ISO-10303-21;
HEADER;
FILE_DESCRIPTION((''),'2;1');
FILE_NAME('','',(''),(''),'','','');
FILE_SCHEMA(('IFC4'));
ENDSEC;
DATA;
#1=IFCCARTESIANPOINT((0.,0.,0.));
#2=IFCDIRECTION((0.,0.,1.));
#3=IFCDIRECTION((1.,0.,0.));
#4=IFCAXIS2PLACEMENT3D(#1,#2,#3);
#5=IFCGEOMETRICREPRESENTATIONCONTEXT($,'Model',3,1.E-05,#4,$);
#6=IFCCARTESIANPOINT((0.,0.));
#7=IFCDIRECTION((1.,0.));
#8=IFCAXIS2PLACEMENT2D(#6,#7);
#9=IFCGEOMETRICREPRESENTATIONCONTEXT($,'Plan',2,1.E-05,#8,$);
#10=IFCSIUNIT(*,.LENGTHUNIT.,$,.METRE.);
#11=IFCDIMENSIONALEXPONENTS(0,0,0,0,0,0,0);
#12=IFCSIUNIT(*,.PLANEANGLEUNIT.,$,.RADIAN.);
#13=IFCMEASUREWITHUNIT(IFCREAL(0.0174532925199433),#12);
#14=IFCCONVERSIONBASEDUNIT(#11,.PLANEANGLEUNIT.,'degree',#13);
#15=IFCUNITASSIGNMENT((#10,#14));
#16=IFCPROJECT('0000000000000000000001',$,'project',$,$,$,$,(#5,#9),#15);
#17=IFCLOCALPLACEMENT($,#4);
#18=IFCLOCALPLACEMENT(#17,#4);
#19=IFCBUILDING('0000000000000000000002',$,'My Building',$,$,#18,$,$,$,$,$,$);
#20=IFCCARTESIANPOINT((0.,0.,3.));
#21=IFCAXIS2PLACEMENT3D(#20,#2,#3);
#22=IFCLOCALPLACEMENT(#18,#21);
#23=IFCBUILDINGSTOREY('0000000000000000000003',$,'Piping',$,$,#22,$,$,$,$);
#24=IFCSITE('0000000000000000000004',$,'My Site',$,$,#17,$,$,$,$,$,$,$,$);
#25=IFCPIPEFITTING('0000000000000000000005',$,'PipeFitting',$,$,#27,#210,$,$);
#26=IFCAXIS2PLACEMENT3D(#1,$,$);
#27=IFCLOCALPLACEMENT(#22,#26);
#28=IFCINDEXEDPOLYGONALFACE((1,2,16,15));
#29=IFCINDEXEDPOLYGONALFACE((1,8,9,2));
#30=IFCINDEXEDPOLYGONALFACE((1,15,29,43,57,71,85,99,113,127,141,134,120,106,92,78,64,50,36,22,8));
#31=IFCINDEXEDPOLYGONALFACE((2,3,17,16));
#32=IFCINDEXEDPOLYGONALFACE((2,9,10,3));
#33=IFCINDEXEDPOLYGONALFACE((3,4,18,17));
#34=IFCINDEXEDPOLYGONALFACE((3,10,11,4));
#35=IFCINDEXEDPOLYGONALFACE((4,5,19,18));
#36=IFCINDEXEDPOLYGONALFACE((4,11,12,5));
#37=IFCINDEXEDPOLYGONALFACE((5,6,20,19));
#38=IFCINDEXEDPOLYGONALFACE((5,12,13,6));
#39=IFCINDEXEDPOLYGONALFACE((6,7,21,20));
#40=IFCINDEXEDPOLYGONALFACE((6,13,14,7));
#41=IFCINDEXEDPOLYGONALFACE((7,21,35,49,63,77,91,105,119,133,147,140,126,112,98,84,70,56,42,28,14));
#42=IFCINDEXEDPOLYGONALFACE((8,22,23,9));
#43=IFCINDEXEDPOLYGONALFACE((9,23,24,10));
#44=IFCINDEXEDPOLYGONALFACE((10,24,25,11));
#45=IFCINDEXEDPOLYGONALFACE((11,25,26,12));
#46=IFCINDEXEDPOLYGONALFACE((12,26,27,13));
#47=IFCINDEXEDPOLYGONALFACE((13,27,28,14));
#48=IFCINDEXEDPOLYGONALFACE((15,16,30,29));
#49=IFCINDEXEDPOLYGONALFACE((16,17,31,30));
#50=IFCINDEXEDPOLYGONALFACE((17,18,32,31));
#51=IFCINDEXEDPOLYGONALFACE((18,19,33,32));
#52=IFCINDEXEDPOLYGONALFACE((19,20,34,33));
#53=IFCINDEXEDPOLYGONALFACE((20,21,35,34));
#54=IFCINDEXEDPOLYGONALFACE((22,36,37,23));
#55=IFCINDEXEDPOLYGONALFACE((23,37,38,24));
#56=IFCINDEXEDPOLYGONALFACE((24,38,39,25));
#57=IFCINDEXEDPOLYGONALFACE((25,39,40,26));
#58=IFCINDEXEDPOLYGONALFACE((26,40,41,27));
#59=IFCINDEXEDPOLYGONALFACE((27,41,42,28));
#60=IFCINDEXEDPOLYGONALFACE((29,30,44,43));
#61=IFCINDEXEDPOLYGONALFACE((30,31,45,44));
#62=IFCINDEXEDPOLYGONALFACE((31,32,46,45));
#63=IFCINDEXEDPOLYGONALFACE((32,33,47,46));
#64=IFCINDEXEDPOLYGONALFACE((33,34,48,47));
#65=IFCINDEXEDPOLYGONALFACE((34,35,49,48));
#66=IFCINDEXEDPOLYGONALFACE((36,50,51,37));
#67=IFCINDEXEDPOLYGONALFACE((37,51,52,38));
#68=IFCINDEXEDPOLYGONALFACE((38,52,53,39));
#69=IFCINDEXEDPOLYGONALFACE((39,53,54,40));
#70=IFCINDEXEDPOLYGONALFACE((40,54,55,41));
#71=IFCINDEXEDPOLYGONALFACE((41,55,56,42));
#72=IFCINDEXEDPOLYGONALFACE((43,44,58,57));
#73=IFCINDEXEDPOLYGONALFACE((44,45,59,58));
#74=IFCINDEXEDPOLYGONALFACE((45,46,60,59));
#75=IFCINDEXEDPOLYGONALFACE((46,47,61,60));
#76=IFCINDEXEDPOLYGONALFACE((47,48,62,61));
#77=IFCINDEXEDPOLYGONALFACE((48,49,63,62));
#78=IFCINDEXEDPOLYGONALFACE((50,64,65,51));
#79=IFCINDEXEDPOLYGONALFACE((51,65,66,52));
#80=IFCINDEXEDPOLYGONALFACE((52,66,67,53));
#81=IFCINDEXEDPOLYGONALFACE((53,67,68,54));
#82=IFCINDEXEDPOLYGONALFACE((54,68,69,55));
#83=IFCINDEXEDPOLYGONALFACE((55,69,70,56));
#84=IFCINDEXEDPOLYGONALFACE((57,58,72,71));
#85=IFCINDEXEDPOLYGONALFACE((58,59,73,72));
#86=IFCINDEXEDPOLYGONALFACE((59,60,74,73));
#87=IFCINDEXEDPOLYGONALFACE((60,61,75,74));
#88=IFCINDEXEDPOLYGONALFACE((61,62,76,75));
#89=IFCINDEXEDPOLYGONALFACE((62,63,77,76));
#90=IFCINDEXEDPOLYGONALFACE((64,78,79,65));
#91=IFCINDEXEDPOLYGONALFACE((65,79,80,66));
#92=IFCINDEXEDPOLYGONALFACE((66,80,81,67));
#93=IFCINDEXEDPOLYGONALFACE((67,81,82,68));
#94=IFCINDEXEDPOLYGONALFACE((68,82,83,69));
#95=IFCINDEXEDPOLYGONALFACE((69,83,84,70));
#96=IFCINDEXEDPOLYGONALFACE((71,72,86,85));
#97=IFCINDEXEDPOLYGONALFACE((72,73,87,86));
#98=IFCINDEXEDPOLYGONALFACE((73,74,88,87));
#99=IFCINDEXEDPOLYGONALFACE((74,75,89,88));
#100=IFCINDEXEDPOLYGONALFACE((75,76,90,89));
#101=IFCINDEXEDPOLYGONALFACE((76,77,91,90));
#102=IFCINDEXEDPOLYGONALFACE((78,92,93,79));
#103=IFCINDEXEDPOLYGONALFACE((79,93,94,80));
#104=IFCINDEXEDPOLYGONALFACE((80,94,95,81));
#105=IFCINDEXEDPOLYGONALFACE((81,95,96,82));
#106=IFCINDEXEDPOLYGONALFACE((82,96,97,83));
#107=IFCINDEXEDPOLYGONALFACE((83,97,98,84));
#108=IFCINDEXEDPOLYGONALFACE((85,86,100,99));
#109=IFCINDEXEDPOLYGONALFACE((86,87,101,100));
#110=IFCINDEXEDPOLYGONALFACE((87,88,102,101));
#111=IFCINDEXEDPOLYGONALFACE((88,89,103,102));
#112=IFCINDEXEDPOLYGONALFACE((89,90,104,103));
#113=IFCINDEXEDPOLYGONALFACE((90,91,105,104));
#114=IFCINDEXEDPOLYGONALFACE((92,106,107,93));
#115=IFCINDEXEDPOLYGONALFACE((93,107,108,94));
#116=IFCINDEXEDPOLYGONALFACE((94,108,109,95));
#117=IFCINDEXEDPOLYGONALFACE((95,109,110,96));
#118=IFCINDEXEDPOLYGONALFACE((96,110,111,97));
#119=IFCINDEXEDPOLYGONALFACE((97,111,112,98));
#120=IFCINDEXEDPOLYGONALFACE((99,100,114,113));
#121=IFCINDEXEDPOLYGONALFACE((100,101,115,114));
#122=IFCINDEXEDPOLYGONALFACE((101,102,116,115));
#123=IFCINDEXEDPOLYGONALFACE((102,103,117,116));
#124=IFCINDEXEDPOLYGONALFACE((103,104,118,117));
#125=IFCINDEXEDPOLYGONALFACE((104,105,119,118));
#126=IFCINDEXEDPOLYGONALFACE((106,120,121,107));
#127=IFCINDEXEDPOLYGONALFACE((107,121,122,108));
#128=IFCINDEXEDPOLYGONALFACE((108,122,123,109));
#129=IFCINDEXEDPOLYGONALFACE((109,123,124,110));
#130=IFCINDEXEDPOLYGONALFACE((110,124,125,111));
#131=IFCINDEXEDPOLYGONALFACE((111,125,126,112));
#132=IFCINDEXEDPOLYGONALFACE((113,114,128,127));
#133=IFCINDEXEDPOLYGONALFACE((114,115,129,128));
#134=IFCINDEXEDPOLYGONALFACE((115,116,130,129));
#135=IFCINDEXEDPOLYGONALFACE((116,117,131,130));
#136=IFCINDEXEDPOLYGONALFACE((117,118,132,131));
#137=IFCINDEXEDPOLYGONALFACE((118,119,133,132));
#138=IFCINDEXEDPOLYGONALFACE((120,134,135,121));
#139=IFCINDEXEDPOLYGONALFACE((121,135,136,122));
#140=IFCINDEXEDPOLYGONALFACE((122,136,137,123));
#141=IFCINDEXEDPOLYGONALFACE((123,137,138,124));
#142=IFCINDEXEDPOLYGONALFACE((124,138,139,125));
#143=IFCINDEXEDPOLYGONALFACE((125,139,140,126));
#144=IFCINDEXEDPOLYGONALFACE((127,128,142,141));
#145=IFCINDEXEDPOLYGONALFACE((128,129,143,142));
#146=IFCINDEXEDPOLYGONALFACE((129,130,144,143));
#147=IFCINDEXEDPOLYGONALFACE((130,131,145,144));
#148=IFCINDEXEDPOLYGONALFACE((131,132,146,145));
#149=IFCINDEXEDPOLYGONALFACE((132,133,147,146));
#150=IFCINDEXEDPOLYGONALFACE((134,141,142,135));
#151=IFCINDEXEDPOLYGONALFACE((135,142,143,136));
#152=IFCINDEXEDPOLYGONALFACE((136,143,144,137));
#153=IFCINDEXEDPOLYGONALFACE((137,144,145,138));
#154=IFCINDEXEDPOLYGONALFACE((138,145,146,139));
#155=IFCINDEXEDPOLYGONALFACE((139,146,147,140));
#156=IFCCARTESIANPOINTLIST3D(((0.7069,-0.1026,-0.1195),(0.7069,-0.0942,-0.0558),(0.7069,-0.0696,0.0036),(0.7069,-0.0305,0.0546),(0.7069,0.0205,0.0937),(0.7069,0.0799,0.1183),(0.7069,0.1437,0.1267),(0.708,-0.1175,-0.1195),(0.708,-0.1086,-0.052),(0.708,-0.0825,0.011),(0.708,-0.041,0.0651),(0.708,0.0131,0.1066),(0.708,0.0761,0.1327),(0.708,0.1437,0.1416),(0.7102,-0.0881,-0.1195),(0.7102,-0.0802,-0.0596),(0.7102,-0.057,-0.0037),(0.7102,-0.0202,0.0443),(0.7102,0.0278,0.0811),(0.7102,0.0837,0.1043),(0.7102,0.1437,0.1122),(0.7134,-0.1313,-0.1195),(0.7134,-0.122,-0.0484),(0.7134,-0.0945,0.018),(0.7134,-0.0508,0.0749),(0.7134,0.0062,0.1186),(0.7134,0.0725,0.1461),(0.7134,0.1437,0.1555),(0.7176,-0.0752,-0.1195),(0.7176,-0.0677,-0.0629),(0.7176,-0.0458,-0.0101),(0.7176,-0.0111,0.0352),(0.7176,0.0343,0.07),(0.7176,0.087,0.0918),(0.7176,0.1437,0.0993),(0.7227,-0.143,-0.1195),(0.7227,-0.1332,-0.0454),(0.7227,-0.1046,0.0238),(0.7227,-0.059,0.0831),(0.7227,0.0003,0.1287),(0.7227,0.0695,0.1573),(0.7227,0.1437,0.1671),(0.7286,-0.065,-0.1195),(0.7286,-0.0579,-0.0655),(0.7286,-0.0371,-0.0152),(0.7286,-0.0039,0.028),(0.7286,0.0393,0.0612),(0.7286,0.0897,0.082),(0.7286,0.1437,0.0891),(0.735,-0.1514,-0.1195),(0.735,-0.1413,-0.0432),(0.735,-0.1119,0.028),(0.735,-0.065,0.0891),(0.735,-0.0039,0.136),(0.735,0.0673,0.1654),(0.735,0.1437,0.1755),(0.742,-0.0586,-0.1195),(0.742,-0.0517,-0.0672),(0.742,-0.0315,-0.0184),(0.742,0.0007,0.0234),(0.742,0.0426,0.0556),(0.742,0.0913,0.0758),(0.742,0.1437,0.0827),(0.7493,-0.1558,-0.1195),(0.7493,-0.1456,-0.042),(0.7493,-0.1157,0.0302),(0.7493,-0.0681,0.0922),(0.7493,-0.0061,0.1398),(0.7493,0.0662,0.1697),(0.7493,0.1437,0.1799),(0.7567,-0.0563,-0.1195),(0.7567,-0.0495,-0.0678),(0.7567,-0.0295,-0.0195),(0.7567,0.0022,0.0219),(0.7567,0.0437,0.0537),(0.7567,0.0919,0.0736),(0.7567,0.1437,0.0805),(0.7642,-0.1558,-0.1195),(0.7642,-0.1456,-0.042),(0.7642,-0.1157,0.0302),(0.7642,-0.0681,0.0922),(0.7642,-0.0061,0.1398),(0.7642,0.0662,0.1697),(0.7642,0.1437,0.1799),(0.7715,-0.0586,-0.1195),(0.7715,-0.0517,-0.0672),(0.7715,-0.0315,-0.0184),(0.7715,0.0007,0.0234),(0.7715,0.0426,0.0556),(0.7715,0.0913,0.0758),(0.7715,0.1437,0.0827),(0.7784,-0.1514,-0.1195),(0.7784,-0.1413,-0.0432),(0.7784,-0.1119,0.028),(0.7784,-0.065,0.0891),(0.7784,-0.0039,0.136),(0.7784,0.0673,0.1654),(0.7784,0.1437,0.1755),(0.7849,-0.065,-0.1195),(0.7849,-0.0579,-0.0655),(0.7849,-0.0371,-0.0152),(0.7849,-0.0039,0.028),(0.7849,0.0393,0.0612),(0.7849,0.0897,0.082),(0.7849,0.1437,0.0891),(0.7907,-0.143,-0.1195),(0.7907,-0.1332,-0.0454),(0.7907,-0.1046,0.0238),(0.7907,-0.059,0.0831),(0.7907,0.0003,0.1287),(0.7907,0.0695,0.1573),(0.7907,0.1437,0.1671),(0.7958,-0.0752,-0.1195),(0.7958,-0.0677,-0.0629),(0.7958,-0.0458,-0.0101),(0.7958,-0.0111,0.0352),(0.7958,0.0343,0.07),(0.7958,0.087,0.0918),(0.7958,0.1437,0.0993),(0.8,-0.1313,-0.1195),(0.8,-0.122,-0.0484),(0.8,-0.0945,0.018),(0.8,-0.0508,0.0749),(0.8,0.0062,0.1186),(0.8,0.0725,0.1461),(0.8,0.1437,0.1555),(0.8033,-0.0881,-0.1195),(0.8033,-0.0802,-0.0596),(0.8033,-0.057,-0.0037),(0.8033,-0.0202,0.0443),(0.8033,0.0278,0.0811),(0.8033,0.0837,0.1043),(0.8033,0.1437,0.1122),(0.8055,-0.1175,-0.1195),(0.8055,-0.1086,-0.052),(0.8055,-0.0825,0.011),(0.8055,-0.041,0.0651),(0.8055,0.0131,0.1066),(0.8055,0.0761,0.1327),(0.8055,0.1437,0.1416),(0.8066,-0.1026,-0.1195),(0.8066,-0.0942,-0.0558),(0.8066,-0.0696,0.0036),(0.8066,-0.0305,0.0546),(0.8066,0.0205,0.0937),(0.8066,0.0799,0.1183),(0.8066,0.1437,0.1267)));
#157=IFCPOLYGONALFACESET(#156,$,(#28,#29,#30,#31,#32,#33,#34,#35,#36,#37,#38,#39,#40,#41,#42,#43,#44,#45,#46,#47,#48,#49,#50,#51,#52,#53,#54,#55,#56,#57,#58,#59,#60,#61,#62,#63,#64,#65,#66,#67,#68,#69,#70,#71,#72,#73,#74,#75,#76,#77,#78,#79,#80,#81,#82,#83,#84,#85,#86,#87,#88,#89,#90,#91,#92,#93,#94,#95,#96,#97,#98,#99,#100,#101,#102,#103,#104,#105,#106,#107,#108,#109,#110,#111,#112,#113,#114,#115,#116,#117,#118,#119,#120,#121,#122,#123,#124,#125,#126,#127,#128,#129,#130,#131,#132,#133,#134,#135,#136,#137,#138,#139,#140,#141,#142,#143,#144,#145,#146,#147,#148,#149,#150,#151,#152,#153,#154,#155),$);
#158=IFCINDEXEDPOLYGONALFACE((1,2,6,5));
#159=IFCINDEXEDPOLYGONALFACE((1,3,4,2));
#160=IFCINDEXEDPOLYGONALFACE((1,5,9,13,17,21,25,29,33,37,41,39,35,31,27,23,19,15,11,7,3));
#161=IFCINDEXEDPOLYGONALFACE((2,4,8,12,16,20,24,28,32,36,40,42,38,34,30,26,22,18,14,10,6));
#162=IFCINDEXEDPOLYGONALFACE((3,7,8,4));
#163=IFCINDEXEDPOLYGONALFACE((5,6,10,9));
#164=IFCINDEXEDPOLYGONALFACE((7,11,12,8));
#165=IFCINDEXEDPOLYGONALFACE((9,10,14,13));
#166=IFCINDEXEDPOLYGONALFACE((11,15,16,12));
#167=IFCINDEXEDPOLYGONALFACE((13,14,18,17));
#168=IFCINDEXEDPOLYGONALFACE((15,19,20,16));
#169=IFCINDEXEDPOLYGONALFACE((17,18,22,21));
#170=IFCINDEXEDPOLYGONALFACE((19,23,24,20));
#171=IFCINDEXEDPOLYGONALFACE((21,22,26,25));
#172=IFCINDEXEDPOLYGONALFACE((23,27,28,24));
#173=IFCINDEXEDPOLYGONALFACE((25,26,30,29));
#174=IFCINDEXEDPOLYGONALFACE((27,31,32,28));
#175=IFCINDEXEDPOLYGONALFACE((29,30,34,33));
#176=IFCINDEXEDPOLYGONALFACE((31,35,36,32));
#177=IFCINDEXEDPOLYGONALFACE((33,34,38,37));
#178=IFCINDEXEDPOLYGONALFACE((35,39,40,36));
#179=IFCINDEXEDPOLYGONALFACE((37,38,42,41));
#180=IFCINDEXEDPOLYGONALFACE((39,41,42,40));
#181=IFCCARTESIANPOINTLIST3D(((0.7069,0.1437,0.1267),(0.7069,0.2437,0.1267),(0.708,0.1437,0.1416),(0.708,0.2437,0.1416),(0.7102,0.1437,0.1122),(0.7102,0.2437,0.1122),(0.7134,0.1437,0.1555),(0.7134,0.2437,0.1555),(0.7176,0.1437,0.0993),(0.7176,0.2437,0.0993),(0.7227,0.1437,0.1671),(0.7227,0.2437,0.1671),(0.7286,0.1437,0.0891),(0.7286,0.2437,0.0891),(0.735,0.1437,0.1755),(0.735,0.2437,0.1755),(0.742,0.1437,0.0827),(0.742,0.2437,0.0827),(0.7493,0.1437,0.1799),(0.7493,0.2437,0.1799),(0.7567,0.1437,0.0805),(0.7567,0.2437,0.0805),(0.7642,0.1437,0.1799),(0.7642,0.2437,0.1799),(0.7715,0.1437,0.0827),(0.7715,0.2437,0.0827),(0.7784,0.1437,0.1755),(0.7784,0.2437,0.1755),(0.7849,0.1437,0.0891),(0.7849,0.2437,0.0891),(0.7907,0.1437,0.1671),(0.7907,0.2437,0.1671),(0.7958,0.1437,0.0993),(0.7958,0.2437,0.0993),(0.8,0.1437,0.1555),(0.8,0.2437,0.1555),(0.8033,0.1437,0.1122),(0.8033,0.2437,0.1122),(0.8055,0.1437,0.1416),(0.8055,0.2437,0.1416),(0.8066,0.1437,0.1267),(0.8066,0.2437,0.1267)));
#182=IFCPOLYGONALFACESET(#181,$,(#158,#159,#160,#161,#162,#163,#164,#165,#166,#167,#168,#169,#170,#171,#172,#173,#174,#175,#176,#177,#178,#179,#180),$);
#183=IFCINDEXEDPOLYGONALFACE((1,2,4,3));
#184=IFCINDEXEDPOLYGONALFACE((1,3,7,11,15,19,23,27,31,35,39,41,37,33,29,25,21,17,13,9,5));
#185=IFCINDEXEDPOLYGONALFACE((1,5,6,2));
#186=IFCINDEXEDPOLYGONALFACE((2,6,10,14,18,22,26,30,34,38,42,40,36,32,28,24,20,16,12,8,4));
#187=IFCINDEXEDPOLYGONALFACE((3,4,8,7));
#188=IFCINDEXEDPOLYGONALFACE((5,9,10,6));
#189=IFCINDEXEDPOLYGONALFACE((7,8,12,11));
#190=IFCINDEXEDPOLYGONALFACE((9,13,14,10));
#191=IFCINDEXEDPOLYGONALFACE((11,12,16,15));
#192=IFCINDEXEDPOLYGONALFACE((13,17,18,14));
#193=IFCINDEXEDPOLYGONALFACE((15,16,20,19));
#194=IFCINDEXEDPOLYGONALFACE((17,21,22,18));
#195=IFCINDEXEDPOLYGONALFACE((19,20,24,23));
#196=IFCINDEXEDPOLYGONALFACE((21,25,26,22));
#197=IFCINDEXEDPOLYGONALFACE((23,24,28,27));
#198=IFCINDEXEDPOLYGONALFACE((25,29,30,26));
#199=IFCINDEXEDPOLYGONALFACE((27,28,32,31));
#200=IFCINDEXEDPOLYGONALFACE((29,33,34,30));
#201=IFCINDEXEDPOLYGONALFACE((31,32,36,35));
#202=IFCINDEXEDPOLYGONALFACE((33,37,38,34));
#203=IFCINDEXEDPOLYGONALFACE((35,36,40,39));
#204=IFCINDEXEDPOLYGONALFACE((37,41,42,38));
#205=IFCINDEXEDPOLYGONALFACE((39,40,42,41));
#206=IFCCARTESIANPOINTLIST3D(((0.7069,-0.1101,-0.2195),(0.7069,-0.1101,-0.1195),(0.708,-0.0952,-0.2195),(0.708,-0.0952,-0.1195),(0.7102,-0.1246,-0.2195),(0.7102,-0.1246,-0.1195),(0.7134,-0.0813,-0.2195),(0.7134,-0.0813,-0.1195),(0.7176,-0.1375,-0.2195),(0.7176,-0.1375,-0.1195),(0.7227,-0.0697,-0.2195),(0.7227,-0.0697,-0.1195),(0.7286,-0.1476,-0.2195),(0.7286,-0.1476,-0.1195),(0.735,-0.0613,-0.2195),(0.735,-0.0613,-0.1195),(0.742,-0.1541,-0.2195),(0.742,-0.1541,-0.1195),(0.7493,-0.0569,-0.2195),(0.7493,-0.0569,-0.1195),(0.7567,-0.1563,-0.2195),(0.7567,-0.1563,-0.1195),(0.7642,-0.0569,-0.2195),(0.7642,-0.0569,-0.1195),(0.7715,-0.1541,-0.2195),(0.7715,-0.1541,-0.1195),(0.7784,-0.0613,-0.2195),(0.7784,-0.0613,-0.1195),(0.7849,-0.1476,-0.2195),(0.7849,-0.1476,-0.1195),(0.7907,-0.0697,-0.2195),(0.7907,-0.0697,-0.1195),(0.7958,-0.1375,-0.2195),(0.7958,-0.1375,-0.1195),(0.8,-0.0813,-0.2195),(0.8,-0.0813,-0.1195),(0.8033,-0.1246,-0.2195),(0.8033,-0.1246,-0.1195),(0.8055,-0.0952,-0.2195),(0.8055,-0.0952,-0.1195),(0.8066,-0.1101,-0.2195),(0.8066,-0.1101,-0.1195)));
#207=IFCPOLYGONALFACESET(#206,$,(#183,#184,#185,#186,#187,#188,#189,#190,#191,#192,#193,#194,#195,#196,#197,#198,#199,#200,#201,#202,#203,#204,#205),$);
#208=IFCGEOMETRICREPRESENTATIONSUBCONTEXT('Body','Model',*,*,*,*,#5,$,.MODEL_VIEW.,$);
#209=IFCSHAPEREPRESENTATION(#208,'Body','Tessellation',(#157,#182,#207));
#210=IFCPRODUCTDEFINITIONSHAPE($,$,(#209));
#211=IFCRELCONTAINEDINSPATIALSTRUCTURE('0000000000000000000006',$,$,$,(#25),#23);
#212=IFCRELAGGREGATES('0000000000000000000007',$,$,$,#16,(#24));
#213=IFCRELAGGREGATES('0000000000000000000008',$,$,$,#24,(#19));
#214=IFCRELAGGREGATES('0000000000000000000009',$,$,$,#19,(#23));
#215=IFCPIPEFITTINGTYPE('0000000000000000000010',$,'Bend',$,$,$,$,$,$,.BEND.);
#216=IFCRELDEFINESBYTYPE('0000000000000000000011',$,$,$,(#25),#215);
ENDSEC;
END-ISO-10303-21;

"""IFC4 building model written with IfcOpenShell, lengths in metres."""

from ifc_helpers import new_model, entity, si_unit, converted_unit, frame, origin_with_axes, origin_2d_with_axis, place, context, subcontext, project, spatial, circle, extrude, source, transform, mapped, type_object, type_shapes, element, save


model = new_model("IFC4")

# Units and contexts
model_context = context("Model", 3, precision=1e-05, world=origin_with_axes())
plan_context = context("Plan", 2, precision=1e-05, world=origin_2d_with_axis())
body_context = subcontext(model_context, "Body", "Model", "MODEL_VIEW")
ifc_project = project(units=[si_unit("LENGTHUNIT", "METRE"), converted_unit("PLANEANGLEUNIT", "degree", entity("IfcReal", 0.0174532925199433), si_unit("PLANEANGLEUNIT", "RADIAN"), dimensions=[0, 0, 0, 0, 0, 0, 0])], contexts=[model_context, plan_context])

# Site, building, storey
site_placement = place(None, origin_with_axes())
site = spatial("IfcSite", under=ifc_project, at=site_placement, Name="My Site")
building_placement = place(site_placement, origin_with_axes())
building = spatial("IfcBuilding", under=site, at=building_placement, Name="My Building")
storey_placement = place(building_placement, frame((0.0, 0.0, 3.0), z_axis=(0.0, 0.0, 1.0), x_axis=(1.0, 0.0, 0.0)))
storey = spatial("IfcBuildingStorey", under=building, at=storey_placement, Name="Piping")

# Pipe fitting
pipe_fitting_type_1 = type_object("IfcPipeFittingType", Name="Bend", PredefinedType="BEND")
shared_shape_1 = source(origin_with_axes(), body_context, "Body", "SolidModel", [
    entity("IfcSweptDiskSolid", entity("IfcIndexedPolyCurve", entity("IfcCartesianPointList3D", [[0.0, 0.0, 0.1], [0.0732, 0.0, 0.2768], [0.25, 0.0, 0.35]]), [entity("IfcArcIndex", [1, 2, 3])]), 0.05),
    extrude(circle(Radius=0.05), origin_with_axes(), (0.0, 0.0, 1.0), 0.1),
    extrude(circle(Radius=0.05), frame((0.25, 0.0, 0.35), z_axis=(1.0, 0.0, 0.000001), x_axis=(-0.000001, 0.0, 1.0)), (0.0, 0.0, 1.0), 0.1),
])
type_shapes(pipe_fitting_type_1, [shared_shape_1])
for number, where, z_axis, x_axis, name in (
    (1, (0.7567, 0.2437, 0.1305), (0.0, -1.0, 0.0), (0.0, 0.0, -1.0), "PipeFitting"),
):
    element("IfcPipeFitting", number, at=place(storey_placement, frame(where, z_axis=z_axis, x_axis=x_axis)), inside=storey, type_object=pipe_fitting_type_1, Name=name, context=body_context, shape_type="MappedRepresentation", body=[
        mapped(shared_shape_1, transform((0.0, 0.0, 0.0), x_axis=(1.0, 0.0, 0.0), y_axis=(0.0, 1.0, 0.0), z_axis=(0.0, 0.0, 1.0), scale=1.0)),
    ])

save(model, "model.ifc")
